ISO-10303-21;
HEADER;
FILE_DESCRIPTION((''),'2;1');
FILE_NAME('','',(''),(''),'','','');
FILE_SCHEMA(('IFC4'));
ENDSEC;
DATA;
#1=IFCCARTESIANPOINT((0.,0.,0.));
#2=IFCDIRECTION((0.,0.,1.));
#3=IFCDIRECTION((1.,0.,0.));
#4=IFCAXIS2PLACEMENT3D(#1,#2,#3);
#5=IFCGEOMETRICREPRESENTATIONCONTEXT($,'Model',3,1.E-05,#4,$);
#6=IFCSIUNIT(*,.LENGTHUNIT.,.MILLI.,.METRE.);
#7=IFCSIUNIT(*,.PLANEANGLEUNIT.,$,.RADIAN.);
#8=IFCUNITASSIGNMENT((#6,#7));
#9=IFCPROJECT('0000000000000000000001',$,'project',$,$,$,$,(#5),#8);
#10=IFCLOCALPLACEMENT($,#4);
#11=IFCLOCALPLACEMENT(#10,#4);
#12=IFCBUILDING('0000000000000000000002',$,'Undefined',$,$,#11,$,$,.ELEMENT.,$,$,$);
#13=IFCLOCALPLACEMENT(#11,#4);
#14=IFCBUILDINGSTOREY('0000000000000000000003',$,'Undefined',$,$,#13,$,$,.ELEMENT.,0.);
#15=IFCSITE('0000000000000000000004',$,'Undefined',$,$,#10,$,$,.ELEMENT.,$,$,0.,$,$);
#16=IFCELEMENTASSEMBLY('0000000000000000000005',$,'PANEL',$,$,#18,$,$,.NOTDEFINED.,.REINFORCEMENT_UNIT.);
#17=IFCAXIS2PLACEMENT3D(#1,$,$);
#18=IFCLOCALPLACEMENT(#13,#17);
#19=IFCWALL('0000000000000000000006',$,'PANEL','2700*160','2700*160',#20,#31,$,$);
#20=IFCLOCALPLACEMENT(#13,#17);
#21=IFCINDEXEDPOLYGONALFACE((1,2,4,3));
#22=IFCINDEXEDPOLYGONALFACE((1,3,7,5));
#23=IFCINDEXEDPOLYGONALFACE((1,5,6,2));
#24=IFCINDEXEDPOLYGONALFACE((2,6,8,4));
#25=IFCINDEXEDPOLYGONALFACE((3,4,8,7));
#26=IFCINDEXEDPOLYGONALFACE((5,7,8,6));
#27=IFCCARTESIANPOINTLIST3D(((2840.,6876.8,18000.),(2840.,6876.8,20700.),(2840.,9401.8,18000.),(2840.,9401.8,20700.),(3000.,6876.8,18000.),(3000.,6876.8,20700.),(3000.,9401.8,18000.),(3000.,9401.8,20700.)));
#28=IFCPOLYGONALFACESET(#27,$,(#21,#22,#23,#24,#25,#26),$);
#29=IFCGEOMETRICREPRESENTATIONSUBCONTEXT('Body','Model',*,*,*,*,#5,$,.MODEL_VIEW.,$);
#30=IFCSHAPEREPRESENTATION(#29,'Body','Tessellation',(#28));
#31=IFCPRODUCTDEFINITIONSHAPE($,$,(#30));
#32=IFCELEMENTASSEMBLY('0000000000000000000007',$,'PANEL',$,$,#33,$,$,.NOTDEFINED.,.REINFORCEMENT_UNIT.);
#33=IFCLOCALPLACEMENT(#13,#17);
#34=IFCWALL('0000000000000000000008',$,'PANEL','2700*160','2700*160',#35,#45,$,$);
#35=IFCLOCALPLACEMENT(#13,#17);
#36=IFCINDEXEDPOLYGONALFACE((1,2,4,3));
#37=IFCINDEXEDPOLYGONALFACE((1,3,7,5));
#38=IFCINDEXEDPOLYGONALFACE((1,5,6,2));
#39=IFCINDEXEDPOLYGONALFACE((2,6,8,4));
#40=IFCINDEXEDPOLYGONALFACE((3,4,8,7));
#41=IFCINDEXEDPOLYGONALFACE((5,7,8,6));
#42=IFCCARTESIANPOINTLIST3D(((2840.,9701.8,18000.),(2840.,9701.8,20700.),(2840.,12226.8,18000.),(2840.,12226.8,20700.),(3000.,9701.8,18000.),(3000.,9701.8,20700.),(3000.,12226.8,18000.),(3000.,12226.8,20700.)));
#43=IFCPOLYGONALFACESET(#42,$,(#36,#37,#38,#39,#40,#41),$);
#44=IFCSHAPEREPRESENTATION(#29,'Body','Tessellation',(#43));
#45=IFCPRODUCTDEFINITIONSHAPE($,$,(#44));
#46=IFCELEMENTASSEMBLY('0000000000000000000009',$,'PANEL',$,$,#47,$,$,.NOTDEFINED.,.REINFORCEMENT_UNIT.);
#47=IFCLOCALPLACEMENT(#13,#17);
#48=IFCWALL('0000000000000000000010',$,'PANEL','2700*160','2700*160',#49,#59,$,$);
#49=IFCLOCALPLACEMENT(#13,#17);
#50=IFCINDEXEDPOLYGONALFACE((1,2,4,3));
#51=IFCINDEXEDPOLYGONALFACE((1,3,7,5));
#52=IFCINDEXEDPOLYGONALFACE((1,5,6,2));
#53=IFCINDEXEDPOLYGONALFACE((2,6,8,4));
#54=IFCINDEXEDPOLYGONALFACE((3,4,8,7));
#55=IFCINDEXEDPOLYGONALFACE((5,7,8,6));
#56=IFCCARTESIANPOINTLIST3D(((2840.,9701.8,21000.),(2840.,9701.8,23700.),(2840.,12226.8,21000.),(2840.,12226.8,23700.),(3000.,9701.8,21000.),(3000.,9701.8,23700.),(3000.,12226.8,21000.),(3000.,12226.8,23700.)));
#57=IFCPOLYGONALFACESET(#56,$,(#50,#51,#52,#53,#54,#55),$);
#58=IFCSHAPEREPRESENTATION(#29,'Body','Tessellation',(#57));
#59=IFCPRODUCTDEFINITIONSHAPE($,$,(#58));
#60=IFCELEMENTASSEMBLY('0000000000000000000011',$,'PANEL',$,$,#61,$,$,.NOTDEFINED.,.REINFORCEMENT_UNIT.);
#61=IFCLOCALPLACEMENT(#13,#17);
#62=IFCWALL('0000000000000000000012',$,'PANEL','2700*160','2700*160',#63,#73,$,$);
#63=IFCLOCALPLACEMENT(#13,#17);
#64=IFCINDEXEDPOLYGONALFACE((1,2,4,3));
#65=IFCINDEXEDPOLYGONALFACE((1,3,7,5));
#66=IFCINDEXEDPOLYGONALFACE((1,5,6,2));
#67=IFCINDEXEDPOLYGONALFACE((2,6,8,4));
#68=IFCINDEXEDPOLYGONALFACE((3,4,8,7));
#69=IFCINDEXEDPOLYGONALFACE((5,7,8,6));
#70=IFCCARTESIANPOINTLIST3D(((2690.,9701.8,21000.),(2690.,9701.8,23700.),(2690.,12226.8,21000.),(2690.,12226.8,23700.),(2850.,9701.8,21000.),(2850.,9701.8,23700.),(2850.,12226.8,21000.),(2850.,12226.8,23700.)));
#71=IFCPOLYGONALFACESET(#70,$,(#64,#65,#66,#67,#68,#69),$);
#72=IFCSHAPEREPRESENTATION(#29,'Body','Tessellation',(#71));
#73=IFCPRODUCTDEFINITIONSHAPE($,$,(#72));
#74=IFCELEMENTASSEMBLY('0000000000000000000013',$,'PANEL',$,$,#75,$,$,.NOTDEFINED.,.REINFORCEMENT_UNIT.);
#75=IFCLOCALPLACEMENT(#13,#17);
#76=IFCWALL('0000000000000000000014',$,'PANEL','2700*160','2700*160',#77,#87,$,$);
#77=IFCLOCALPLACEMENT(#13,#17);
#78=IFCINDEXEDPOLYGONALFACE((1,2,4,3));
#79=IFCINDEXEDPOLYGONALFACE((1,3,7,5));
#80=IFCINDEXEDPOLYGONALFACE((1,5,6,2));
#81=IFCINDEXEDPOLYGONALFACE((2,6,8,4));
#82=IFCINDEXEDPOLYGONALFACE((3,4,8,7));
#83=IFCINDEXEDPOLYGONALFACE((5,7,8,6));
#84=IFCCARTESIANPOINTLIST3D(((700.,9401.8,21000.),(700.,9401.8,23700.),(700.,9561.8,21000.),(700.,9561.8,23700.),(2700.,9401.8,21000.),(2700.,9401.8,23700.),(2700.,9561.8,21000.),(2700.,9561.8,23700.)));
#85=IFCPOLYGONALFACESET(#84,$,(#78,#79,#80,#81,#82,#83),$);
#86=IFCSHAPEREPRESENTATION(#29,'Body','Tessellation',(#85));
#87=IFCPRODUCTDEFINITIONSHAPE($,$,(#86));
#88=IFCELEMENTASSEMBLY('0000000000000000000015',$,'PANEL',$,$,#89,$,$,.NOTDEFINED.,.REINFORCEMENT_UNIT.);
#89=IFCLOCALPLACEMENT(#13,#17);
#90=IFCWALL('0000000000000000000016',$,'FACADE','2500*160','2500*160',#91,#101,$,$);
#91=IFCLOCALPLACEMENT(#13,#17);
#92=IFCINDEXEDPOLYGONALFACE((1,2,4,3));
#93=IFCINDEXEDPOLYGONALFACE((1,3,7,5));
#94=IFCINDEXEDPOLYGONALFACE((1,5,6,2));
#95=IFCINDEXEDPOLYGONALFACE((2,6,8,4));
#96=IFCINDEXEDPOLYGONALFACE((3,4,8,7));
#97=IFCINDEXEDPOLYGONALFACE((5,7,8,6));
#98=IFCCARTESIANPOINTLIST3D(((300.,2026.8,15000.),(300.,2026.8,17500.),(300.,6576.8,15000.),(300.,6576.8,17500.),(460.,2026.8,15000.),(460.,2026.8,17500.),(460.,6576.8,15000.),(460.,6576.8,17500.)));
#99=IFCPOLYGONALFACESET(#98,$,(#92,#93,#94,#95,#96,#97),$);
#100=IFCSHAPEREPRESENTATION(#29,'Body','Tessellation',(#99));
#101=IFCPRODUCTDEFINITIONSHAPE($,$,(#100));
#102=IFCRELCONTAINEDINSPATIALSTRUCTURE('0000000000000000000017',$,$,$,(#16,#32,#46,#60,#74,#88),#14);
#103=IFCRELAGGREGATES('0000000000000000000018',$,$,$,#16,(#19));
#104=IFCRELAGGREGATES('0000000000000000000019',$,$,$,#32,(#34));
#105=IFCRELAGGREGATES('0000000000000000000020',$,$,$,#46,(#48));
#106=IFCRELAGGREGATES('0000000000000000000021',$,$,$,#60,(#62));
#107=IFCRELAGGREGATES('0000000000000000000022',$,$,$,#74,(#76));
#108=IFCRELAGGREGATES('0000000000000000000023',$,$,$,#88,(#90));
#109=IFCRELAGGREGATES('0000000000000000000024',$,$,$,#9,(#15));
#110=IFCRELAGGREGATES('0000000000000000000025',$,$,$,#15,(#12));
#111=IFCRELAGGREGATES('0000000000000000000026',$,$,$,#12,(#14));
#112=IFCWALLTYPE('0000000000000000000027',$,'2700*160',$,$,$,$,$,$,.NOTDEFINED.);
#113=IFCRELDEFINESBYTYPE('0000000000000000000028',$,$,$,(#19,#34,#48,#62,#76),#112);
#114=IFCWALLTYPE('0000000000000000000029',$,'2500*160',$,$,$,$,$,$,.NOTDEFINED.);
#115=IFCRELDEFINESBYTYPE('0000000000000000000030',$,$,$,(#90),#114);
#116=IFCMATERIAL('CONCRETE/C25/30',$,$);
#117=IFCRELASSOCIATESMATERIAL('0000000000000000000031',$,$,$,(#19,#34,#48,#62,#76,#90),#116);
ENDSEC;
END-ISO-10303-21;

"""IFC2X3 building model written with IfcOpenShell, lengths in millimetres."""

from ifc_helpers import new_model, si_unit, frame, frame_2d, origin_with_axes, place, context, subcontext, project, spatial, rectangle, extrude, material, type_object, element, aggregate, save


model = new_model("IFC2X3")

# Units and contexts
model_context = context("Model", 3, precision=1e-05, world=origin_with_axes())
body_context = subcontext(model_context, "Body", "Model", "MODEL_VIEW")
ifc_project = project(units=[si_unit("LENGTHUNIT", "METRE", prefix="MILLI"), si_unit("PLANEANGLEUNIT", "RADIAN")], contexts=[model_context])

# Site, building, storey
site_placement = place(None, origin_with_axes())
site = spatial("IfcSite", under=ifc_project, at=site_placement, Name="Undefined", CompositionType="ELEMENT", RefElevation=0.0)
building_placement = place(site_placement, origin_with_axes())
building = spatial("IfcBuilding", under=site, at=building_placement, Name="Undefined", CompositionType="ELEMENT")
storey_placement = place(building_placement, origin_with_axes())
storey = spatial("IfcBuildingStorey", under=building, at=storey_placement, Name="Undefined", CompositionType="ELEMENT", Elevation=0.0)

# Shared definitions
ifc_material_1 = material(Name="CONCRETE/C25/30")

# Element assemblies, walls
wall_type_1 = type_object("IfcWallType", Name="2700*160", PredefinedType="NOTDEFINED")
assembly_1_placement = place(storey_placement, origin_with_axes())
assembly_1 = element("IfcElementAssembly", 1, at=assembly_1_placement, inside=storey, Name="PANEL", AssemblyPlace="NOTDEFINED", PredefinedType="REINFORCEMENT_UNIT")
wall_1_placement = place(assembly_1_placement, frame((2920.0, 6876.8, 18000.0), z_axis=(0.0, 0.0, 1.0), x_axis=(0.0, 1.0, 0.0)))
wall_1 = element("IfcWall", 2, at=wall_1_placement, type_object=wall_type_1, material=ifc_material_1, Name="PANEL", Description="2700*160", ObjectType="2700*160", context=body_context, shape_type="SweptSolid", body=[
    extrude(rectangle(XDim=2525.0, YDim=160.0, at=frame_2d((0.0, 1262.5), x_axis=(0.0, -1.0))), frame((0.0, 0.0, 0.0), z_axis=(0.0, 0.0, 1.0), x_axis=(0.0, -1.0, 0.0)), (0.0, 0.0, 1.0), 2700.0),
])
aggregate(assembly_1, [wall_1])
assembly_2_placement = place(storey_placement, origin_with_axes())
assembly_2 = element("IfcElementAssembly", 3, at=assembly_2_placement, inside=storey, Name="PANEL", AssemblyPlace="NOTDEFINED", PredefinedType="REINFORCEMENT_UNIT")
wall_2_placement = place(assembly_2_placement, frame((2920.0, 9701.8, 18000.0), z_axis=(0.0, 0.0, 1.0), x_axis=(0.0, 1.0, 0.0)))
wall_2 = element("IfcWall", 4, at=wall_2_placement, type_object=wall_type_1, material=ifc_material_1, Name="PANEL", Description="2700*160", ObjectType="2700*160", context=body_context, shape_type="SweptSolid", body=[
    extrude(rectangle(XDim=2525.0, YDim=160.0, at=frame_2d((0.0, 1262.5), x_axis=(0.0, -1.0))), frame((0.0, 0.0, 0.0), z_axis=(0.0, 0.0, 1.0), x_axis=(0.0, -1.0, 0.0)), (0.0, 0.0, 1.0), 2700.0),
])
aggregate(assembly_2, [wall_2])
assembly_3_placement = place(storey_placement, origin_with_axes())
assembly_3 = element("IfcElementAssembly", 5, at=assembly_3_placement, inside=storey, Name="PANEL", AssemblyPlace="NOTDEFINED", PredefinedType="REINFORCEMENT_UNIT")
wall_3_placement = place(assembly_3_placement, frame((2920.0, 9701.8, 21000.0), z_axis=(0.0, 0.0, 1.0), x_axis=(0.0, 1.0, 0.0)))
wall_3 = element("IfcWall", 6, at=wall_3_placement, type_object=wall_type_1, material=ifc_material_1, Name="PANEL", Description="2700*160", ObjectType="2700*160", context=body_context, shape_type="SweptSolid", body=[
    extrude(rectangle(XDim=2525.0, YDim=160.0, at=frame_2d((0.0, 1262.5), x_axis=(0.0, -1.0))), frame((0.0, 0.0, 0.0), z_axis=(0.0, 0.0, 1.0), x_axis=(0.0, -1.0, 0.0)), (0.0, 0.0, 1.0), 2700.0),
])
aggregate(assembly_3, [wall_3])
assembly_4_placement = place(storey_placement, origin_with_axes())
assembly_4 = element("IfcElementAssembly", 7, at=assembly_4_placement, inside=storey, Name="PANEL", AssemblyPlace="NOTDEFINED", PredefinedType="REINFORCEMENT_UNIT")
wall_4_placement = place(assembly_4_placement, frame((2770.0, 9701.8, 21000.0), z_axis=(0.0, 0.0, 1.0), x_axis=(0.0, 1.0, 0.0)))
wall_4 = element("IfcWall", 8, at=wall_4_placement, type_object=wall_type_1, material=ifc_material_1, Name="PANEL", Description="2700*160", ObjectType="2700*160", context=body_context, shape_type="SweptSolid", body=[
    extrude(rectangle(XDim=2525.0, YDim=160.0, at=frame_2d((0.0, 1262.5), x_axis=(0.0, -1.0))), frame((0.0, 0.0, 0.0), z_axis=(0.0, 0.0, 1.0), x_axis=(0.0, -1.0, 0.0)), (0.0, 0.0, 1.0), 2700.0),
])
aggregate(assembly_4, [wall_4])
assembly_5_placement = place(storey_placement, origin_with_axes())
assembly_5 = element("IfcElementAssembly", 9, at=assembly_5_placement, inside=storey, Name="PANEL", AssemblyPlace="NOTDEFINED", PredefinedType="REINFORCEMENT_UNIT")
wall_5_placement = place(assembly_5_placement, frame((700.0, 9481.8, 21000.0), z_axis=(0.0, 0.0, 1.0), x_axis=(1.0, 0.0, 0.0)))
wall_5 = element("IfcWall", 10, at=wall_5_placement, type_object=wall_type_1, material=ifc_material_1, Name="PANEL", Description="2700*160", ObjectType="2700*160", context=body_context, shape_type="SweptSolid", body=[
    extrude(rectangle(XDim=2000.0, YDim=160.0, at=frame_2d((0.0, 1000.0), x_axis=(0.0, -1.0))), frame((0.0, 0.0, 0.0), z_axis=(0.0, 0.0, 1.0), x_axis=(0.0, -1.0, 0.0)), (0.0, 0.0, 1.0), 2700.0),
])
aggregate(assembly_5, [wall_5])
assembly_6_placement = place(storey_placement, origin_with_axes())
assembly_6 = element("IfcElementAssembly", 11, at=assembly_6_placement, inside=storey, Name="PANEL", AssemblyPlace="NOTDEFINED", PredefinedType="REINFORCEMENT_UNIT")
wall_type_2 = type_object("IfcWallType", Name="2500*160", PredefinedType="NOTDEFINED")
wall_6_placement = place(assembly_6_placement, frame((380.0, 6576.8, 15000.0), z_axis=(0.0, 0.0, 1.0), x_axis=(0.0, -1.0, 0.0)))
wall_6 = element("IfcWall", 12, at=wall_6_placement, type_object=wall_type_2, material=ifc_material_1, Name="FACADE", Description="2500*160", ObjectType="2500*160", context=body_context, shape_type="SweptSolid", body=[
    extrude(rectangle(XDim=4550.0, YDim=160.0, at=frame_2d((0.0, 2275.0), x_axis=(0.0, -1.0))), frame((0.0, 0.0, 0.0), z_axis=(0.0, 0.0, 1.0), x_axis=(0.0, -1.0, 0.0)), (0.0, 0.0, 1.0), 2500.0),
])
aggregate(assembly_6, [wall_6])

save(model, "model.ifc")
